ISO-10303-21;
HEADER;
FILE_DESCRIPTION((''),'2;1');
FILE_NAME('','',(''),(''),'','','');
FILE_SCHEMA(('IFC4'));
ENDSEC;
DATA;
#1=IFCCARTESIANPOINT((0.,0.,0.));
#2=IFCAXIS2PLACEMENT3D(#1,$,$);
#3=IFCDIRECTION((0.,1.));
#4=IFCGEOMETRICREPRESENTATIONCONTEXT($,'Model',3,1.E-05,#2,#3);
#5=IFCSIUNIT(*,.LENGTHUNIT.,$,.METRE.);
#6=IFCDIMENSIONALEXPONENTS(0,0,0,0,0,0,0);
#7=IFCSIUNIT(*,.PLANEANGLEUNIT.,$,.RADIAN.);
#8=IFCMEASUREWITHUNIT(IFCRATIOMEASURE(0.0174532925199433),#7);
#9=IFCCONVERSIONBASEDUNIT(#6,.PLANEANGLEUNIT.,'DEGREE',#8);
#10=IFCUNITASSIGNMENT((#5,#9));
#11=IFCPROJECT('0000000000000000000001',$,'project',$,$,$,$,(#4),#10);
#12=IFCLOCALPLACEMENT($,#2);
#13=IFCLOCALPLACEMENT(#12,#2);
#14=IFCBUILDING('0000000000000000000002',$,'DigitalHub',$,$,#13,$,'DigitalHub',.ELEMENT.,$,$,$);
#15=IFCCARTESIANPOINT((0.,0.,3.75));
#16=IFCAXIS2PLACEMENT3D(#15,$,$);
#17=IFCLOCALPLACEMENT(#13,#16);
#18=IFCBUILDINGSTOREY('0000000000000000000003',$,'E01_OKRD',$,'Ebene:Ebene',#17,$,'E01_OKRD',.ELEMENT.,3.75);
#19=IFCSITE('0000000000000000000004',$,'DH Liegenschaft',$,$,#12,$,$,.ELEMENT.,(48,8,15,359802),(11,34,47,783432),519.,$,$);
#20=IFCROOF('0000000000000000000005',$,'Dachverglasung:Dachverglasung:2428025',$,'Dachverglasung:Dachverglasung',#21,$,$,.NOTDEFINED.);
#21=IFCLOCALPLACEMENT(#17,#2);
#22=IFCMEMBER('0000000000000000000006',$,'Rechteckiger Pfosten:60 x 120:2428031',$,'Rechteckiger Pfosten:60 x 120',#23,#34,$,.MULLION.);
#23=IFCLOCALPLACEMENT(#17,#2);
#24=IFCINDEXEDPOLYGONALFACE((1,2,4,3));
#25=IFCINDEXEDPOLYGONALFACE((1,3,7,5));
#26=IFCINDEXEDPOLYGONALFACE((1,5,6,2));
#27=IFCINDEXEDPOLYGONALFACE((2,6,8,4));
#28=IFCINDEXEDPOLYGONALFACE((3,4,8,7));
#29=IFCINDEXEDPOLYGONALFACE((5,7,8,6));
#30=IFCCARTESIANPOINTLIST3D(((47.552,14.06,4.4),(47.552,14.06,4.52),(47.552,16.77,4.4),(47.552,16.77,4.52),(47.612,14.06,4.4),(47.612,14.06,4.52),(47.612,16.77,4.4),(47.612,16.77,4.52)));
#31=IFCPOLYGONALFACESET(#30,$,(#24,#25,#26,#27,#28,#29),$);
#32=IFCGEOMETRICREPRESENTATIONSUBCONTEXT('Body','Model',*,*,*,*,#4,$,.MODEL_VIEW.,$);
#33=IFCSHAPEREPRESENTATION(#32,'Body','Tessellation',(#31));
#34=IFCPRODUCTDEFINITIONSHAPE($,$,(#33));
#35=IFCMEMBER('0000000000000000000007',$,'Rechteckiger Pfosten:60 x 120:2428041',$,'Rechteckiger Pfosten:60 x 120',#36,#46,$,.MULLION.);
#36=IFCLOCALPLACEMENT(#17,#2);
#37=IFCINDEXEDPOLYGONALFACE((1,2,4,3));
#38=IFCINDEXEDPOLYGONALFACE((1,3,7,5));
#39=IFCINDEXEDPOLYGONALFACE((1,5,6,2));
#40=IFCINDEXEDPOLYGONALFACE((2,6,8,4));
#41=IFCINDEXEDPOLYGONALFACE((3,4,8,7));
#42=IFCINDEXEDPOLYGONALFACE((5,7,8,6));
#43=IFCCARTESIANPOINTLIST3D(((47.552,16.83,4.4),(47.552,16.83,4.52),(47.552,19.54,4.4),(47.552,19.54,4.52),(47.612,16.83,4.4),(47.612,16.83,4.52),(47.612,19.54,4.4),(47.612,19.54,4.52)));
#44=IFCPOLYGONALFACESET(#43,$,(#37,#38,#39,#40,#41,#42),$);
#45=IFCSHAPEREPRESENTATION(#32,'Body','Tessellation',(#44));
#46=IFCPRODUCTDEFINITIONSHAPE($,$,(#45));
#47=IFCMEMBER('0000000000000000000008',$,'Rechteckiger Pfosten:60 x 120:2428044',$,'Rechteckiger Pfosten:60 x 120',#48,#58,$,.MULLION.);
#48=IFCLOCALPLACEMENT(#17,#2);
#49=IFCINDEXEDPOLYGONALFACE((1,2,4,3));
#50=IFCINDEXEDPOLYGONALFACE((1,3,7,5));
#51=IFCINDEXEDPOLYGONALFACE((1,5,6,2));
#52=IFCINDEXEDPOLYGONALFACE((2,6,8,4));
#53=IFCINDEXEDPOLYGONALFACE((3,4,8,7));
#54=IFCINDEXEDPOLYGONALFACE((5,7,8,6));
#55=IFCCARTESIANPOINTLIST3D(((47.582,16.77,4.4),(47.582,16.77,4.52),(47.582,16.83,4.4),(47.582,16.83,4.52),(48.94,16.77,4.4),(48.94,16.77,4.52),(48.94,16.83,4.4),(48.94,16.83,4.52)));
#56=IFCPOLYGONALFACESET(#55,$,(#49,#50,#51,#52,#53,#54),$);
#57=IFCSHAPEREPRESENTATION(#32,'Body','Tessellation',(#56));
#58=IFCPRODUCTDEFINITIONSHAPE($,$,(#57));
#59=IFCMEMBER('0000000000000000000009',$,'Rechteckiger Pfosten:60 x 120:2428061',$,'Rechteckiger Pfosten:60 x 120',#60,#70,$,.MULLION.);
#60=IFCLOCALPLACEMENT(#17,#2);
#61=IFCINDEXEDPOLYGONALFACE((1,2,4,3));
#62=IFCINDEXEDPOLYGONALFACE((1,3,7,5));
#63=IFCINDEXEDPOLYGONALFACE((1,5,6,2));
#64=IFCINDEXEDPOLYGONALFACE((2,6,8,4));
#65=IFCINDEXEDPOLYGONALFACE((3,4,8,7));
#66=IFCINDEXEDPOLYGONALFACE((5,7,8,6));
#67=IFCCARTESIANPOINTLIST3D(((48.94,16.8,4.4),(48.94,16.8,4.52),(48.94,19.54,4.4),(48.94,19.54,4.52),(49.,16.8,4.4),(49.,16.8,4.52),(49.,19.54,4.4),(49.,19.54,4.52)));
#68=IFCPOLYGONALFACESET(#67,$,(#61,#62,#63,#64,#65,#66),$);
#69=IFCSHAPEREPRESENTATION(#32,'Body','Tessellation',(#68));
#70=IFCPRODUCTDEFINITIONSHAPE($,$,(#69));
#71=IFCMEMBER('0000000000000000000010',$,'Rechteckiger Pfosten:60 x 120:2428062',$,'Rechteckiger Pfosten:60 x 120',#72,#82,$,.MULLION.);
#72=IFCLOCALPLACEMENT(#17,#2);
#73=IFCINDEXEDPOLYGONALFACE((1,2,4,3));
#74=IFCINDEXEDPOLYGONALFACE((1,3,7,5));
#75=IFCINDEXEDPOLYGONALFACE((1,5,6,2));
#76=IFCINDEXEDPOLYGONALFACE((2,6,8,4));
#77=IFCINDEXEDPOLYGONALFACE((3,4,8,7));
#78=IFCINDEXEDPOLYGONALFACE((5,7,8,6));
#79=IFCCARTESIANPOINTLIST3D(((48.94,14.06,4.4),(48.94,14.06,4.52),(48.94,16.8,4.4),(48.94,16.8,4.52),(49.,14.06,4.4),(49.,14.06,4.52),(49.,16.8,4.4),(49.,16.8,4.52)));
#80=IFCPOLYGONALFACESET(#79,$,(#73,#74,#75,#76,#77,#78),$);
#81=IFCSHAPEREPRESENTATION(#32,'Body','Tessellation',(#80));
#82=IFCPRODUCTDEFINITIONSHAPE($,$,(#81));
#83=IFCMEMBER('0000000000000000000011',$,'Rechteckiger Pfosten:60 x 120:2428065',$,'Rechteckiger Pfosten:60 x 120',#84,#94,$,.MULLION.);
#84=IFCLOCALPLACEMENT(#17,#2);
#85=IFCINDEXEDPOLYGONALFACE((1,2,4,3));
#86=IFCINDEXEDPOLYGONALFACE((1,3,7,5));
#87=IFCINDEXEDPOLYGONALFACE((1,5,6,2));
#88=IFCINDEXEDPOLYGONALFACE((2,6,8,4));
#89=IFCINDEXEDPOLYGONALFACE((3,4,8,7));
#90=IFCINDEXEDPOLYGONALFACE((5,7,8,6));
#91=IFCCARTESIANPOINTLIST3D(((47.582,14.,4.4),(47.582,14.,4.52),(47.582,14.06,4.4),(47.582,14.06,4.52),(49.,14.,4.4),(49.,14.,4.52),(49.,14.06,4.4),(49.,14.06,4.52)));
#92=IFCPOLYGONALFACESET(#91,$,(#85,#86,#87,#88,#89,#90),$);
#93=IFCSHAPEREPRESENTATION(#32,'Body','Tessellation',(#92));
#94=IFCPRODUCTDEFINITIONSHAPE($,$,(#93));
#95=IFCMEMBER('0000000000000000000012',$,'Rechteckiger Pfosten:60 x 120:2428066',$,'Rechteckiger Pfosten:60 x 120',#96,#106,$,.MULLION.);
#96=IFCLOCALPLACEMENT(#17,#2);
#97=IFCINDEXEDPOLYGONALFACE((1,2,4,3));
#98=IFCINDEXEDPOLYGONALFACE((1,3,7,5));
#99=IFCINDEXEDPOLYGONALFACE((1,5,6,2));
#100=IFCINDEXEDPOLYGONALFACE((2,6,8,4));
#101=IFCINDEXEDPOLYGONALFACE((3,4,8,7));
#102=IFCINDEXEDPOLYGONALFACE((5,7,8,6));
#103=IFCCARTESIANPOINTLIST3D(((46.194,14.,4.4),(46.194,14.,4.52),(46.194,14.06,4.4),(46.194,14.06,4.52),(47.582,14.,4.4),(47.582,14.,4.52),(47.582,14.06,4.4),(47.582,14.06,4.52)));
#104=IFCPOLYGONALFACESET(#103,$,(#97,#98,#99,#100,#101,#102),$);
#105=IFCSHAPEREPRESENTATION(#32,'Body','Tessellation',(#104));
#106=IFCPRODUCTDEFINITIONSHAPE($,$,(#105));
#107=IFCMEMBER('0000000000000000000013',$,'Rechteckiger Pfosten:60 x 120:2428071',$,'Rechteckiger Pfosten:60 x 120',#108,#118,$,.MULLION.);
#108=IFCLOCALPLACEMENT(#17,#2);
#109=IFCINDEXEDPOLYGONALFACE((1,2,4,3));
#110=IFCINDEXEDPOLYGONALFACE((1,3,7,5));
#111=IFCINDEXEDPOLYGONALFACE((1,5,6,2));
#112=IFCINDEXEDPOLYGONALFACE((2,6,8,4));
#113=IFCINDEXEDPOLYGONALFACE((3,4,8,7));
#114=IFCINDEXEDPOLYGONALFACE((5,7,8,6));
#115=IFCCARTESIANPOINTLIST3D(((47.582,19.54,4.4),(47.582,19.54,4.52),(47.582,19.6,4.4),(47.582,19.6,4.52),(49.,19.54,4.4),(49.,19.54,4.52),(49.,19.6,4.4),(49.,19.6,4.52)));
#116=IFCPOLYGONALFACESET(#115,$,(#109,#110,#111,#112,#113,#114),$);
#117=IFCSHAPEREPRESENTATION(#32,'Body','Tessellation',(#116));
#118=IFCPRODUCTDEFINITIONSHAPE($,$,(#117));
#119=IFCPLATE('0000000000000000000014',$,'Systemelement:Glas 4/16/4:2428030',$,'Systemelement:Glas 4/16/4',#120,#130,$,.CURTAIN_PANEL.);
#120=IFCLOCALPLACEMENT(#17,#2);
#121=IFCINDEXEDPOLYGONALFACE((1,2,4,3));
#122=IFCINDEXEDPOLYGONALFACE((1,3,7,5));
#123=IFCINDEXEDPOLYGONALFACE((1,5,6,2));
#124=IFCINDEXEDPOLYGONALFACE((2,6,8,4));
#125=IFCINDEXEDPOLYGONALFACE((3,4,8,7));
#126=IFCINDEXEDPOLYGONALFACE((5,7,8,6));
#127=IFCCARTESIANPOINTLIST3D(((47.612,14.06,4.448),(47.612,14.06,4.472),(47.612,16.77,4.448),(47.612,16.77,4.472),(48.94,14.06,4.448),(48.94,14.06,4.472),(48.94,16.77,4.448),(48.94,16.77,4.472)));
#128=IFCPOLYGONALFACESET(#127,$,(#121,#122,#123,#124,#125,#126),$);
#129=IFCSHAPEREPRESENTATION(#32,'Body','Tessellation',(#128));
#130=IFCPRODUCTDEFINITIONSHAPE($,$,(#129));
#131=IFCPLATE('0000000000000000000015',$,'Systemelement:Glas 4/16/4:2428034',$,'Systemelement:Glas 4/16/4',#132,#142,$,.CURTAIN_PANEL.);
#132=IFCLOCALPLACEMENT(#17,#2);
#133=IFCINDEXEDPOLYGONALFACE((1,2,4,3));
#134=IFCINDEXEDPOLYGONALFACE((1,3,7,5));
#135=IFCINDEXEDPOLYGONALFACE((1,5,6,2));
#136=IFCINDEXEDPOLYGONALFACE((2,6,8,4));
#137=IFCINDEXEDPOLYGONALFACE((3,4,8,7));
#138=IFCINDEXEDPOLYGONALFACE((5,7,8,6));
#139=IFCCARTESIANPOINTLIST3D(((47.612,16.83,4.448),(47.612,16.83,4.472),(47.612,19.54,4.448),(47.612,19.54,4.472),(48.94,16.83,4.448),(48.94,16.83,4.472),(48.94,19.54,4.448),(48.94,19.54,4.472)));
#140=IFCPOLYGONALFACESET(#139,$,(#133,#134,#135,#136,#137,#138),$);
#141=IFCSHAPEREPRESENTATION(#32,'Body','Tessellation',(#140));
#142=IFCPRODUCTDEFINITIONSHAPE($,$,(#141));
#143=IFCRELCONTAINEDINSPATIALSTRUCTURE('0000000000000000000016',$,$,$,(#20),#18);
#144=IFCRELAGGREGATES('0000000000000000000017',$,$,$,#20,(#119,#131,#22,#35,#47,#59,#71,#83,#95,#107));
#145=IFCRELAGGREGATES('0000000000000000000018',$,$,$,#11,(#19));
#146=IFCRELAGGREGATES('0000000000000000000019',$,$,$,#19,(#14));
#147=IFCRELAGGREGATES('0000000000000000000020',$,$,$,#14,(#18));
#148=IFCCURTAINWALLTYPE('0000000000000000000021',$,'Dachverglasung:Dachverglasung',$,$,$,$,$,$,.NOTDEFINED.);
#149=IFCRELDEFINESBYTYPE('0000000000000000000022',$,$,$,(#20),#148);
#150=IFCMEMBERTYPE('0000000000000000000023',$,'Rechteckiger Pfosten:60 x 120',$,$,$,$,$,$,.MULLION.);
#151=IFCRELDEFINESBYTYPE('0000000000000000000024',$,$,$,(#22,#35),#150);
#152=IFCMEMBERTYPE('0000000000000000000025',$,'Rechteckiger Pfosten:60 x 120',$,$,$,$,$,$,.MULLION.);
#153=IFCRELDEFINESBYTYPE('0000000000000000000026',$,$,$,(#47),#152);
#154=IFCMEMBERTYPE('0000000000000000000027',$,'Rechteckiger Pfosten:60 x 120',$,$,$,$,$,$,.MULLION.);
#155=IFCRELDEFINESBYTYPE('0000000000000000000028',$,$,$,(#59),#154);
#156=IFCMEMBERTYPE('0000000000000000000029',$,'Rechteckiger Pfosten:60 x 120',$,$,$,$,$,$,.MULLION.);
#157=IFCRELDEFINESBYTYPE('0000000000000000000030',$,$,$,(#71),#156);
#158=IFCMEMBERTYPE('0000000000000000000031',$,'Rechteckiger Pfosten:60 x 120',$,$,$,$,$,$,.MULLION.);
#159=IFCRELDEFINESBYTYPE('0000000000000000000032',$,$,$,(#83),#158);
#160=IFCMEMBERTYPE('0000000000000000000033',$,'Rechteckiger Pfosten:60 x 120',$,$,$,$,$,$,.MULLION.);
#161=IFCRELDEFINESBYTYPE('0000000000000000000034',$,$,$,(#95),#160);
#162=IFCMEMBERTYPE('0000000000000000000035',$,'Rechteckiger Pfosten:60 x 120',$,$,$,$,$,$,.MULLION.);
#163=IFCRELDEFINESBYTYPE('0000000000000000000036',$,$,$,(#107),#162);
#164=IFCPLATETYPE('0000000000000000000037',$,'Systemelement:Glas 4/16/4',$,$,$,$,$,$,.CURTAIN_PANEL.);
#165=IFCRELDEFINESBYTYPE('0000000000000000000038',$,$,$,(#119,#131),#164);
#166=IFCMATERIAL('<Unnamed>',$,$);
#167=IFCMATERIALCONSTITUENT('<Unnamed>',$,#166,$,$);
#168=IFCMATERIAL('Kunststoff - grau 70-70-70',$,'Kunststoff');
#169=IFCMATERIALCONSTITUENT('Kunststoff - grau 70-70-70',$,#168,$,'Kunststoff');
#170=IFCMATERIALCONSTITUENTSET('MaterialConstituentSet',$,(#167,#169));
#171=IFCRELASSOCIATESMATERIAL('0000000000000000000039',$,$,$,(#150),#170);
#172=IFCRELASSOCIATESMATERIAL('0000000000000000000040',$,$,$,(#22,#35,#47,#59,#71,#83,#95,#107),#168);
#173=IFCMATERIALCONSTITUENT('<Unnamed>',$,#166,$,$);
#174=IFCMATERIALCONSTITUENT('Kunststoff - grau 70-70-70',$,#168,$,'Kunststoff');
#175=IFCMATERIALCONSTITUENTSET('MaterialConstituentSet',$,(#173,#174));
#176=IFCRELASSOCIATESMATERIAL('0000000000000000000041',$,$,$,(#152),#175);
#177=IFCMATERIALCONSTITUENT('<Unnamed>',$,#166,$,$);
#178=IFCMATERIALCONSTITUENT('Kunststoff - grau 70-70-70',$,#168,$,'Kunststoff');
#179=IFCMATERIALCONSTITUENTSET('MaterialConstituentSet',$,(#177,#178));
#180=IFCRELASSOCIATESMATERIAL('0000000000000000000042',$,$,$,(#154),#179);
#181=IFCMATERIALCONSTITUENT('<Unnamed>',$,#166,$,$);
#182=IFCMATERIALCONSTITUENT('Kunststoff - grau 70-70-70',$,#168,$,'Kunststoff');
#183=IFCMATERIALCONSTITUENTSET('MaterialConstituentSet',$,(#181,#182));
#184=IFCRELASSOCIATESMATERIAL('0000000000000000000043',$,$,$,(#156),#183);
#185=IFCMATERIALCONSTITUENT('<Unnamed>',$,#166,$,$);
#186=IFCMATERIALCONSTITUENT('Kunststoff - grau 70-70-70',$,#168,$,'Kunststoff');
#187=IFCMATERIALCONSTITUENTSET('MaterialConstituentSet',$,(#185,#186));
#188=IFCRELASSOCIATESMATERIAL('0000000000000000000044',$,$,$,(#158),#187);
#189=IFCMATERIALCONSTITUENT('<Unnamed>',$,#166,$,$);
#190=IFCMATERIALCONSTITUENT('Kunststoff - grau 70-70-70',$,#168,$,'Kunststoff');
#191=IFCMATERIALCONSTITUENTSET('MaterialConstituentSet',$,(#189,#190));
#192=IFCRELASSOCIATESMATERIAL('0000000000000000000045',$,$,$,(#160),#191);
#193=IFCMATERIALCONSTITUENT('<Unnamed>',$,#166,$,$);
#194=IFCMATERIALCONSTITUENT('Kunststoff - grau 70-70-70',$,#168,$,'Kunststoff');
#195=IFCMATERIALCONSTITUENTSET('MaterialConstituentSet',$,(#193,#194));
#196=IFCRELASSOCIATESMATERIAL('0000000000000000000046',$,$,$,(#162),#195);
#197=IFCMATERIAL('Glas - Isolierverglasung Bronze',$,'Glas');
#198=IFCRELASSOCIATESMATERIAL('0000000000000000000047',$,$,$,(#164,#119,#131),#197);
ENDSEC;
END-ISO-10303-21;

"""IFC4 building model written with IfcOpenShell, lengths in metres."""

from ifc_helpers import new_model, entity, si_unit, converted_unit, direction, frame, origin, place, context, subcontext, project, spatial, indexed_curve, outline, extrude, source, transform, mapped, material, constituent, constituent_set, type_object, type_shapes, element, aggregate, save


model = new_model("IFC4")

# Units and contexts
model_context = context("Model", 3, precision=1e-05, world=origin(), true_north=direction((0.0, 1.0)))
body_context = subcontext(model_context, "Body", "Model", "MODEL_VIEW")
ifc_project = project(units=[si_unit("LENGTHUNIT", "METRE"), converted_unit("PLANEANGLEUNIT", "DEGREE", entity("IfcRatioMeasure", 0.0174532925199433), si_unit("PLANEANGLEUNIT", "RADIAN"), dimensions=[0, 0, 0, 0, 0, 0, 0])], contexts=[model_context])

# Site, building, storey
site_placement = place(None, frame((0.0, 0.0, 0.0)))
site = spatial("IfcSite", under=ifc_project, at=site_placement, Name="DH Liegenschaft", CompositionType="ELEMENT", RefLatitude=(48, 8, 15, 359802), RefLongitude=(11, 34, 47, 783432), RefElevation=519.0)
building_placement = place(site_placement, origin())
building = spatial("IfcBuilding", under=site, at=building_placement, Name="DigitalHub", LongName="DigitalHub", CompositionType="ELEMENT")
storey_placement = place(building_placement, frame((0.0, 0.0, 3.75)))
storey = spatial("IfcBuildingStorey", under=building, at=storey_placement, Name="E01_OKRD", ObjectType="Ebene:Ebene", LongName="E01_OKRD", CompositionType="ELEMENT", Elevation=3.75)

# Roof, members, plates
curtain_wall_type = type_object("IfcCurtainWallType", Name="Dachverglasung:Dachverglasung", PredefinedType="NOTDEFINED")
roof_placement = place(storey_placement, frame((0.0, 0.0, -3.75)))
roof = element("IfcRoof", 1, at=roof_placement, inside=storey, type_object=curtain_wall_type, Name="Dachverglasung:Dachverglasung:2428025", ObjectType="Dachverglasung:Dachverglasung", PredefinedType="NOTDEFINED")
ifc_material_1 = material(Name="Kunststoff - grau 70-70-70", Category="Kunststoff")
ifc_material_2 = material(Name="<Unnamed>")
ifc_constituent_1 = constituent(ifc_material_2, Name="<Unnamed>")
ifc_constituent_2 = constituent(ifc_material_1, Name="Kunststoff - grau 70-70-70", Category="Kunststoff")
ifc_constituent_set_1 = constituent_set(constituents=[ifc_constituent_1, ifc_constituent_2], Name="MaterialConstituentSet")
member_type_1 = type_object("IfcMemberType", Name="Rechteckiger Pfosten:60 x 120", PredefinedType="MULLION", material=ifc_constituent_set_1)
shared_shape_1 = source(origin(), body_context, "Body", "SweptSolid", [
    extrude(outline(indexed_curve([(-0.06, -0.03), (0.06, -0.03), (0.06, 0.03), (-0.06, 0.03), (-0.06, -0.03)], self_intersect=False)), frame((0.0, 0.0, -2.71), z_axis=(0.0, 0.0, 1.0), x_axis=(0.0, -1.0, 0.0)), (0.0, 0.0, 1.0), 2.71),
])
type_shapes(member_type_1, [shared_shape_1])
member_1_placement = place(storey_placement, frame((47.582, 14.06, 4.46), z_axis=(0.0, -1.0, 0.0), x_axis=(-1.0, 0.0, 0.0)))
member_1 = element("IfcMember", 2, at=member_1_placement, type_object=member_type_1, material=ifc_material_1, Name="Rechteckiger Pfosten:60 x 120:2428031", ObjectType="Rechteckiger Pfosten:60 x 120", PredefinedType="MULLION", context=body_context, shape_type="MappedRepresentation", body=[
    mapped(shared_shape_1, transform((0.0, 0.0, 0.0), scale=1.0)),
])
member_2_placement = place(storey_placement, frame((47.582, 16.83, 4.46), z_axis=(0.0, -1.0, 0.0), x_axis=(-1.0, 0.0, 0.0)))
member_2 = element("IfcMember", 3, at=member_2_placement, type_object=member_type_1, material=ifc_material_1, Name="Rechteckiger Pfosten:60 x 120:2428041", ObjectType="Rechteckiger Pfosten:60 x 120", PredefinedType="MULLION", context=body_context, shape_type="MappedRepresentation", body=[
    mapped(shared_shape_1, transform((0.0, 0.0, 0.0), scale=1.0)),
])
ifc_constituent_3 = constituent(ifc_material_2, Name="<Unnamed>")
ifc_constituent_4 = constituent(ifc_material_1, Name="Kunststoff - grau 70-70-70", Category="Kunststoff")
ifc_constituent_set_2 = constituent_set(constituents=[ifc_constituent_3, ifc_constituent_4], Name="MaterialConstituentSet")
member_type_2 = type_object("IfcMemberType", Name="Rechteckiger Pfosten:60 x 120", PredefinedType="MULLION", material=ifc_constituent_set_2)
shared_shape_2 = source(origin(), body_context, "Body", "SweptSolid", [
    extrude(outline(indexed_curve([(-0.06, -0.03), (0.06, -0.03), (0.06, 0.03), (-0.06, 0.03), (-0.06, -0.03)], self_intersect=False)), frame((0.0, 0.0, -1.358), z_axis=(0.0, 0.0, 1.0), x_axis=(0.0, -1.0, 0.0)), (0.0, 0.0, 1.0), 1.358),
])
type_shapes(member_type_2, [shared_shape_2])
member_3_placement = place(storey_placement, frame((47.582, 16.8, 4.46), z_axis=(-1.0, 0.0, 0.0), x_axis=(0.0, 1.0, 0.0)))
member_3 = element("IfcMember", 4, at=member_3_placement, type_object=member_type_2, material=ifc_material_1, Name="Rechteckiger Pfosten:60 x 120:2428044", ObjectType="Rechteckiger Pfosten:60 x 120", PredefinedType="MULLION", context=body_context, shape_type="MappedRepresentation", body=[
    mapped(shared_shape_2, transform((0.0, 0.0, 0.0), scale=1.0)),
])
ifc_constituent_5 = constituent(ifc_material_2, Name="<Unnamed>")
ifc_constituent_6 = constituent(ifc_material_1, Name="Kunststoff - grau 70-70-70", Category="Kunststoff")
ifc_constituent_set_3 = constituent_set(constituents=[ifc_constituent_5, ifc_constituent_6], Name="MaterialConstituentSet")
member_type_3 = type_object("IfcMemberType", Name="Rechteckiger Pfosten:60 x 120", PredefinedType="MULLION", material=ifc_constituent_set_3)
shared_shape_3 = source(origin(), body_context, "Body", "SweptSolid", [
    extrude(outline(indexed_curve([(-0.06, -0.03), (0.06, -0.03), (0.06, 0.03), (-0.06, 0.03), (-0.06, -0.03)], self_intersect=False)), frame((-0.03, 0.0, -2.74), z_axis=(0.0, 0.0, 1.0), x_axis=(0.0, -1.0, 0.0)), (0.0, 0.0, 1.0), 2.74),
])
type_shapes(member_type_3, [shared_shape_3])
member_4_placement = place(storey_placement, frame((49.0, 19.54, 4.46), z_axis=(0.0, 1.0, 0.0), x_axis=(1.0, 0.0, 0.0)))
member_4 = element("IfcMember", 5, at=member_4_placement, type_object=member_type_3, material=ifc_material_1, Name="Rechteckiger Pfosten:60 x 120:2428061", ObjectType="Rechteckiger Pfosten:60 x 120", PredefinedType="MULLION", context=body_context, shape_type="MappedRepresentation", body=[
    mapped(shared_shape_3, transform((0.0, 0.0, 0.0), scale=1.0)),
])
ifc_constituent_7 = constituent(ifc_material_2, Name="<Unnamed>")
ifc_constituent_8 = constituent(ifc_material_1, Name="Kunststoff - grau 70-70-70", Category="Kunststoff")
ifc_constituent_set_4 = constituent_set(constituents=[ifc_constituent_7, ifc_constituent_8], Name="MaterialConstituentSet")
member_type_4 = type_object("IfcMemberType", Name="Rechteckiger Pfosten:60 x 120", PredefinedType="MULLION", material=ifc_constituent_set_4)
shared_shape_4 = source(origin(), body_context, "Body", "SweptSolid", [
    extrude(outline(indexed_curve([(-0.06, -0.03), (0.06, -0.03), (0.06, 0.03), (-0.06, 0.03), (-0.06, -0.03)], self_intersect=False)), frame((-0.03, 0.0, -2.74), z_axis=(0.0, 0.0, 1.0), x_axis=(0.0, -1.0, 0.0)), (0.0, 0.0, 1.0), 2.74),
])
type_shapes(member_type_4, [shared_shape_4])
member_5_placement = place(storey_placement, frame((49.0, 16.8, 4.46), z_axis=(0.0, 1.0, 0.0), x_axis=(1.0, 0.0, 0.0)))
member_5 = element("IfcMember", 6, at=member_5_placement, type_object=member_type_4, material=ifc_material_1, Name="Rechteckiger Pfosten:60 x 120:2428062", ObjectType="Rechteckiger Pfosten:60 x 120", PredefinedType="MULLION", context=body_context, shape_type="MappedRepresentation", body=[
    mapped(shared_shape_4, transform((0.0, 0.0, 0.0), scale=1.0)),
])
ifc_constituent_9 = constituent(ifc_material_2, Name="<Unnamed>")
ifc_constituent_10 = constituent(ifc_material_1, Name="Kunststoff - grau 70-70-70", Category="Kunststoff")
ifc_constituent_set_5 = constituent_set(constituents=[ifc_constituent_9, ifc_constituent_10], Name="MaterialConstituentSet")
member_type_5 = type_object("IfcMemberType", Name="Rechteckiger Pfosten:60 x 120", PredefinedType="MULLION", material=ifc_constituent_set_5)
shared_shape_5 = source(origin(), body_context, "Body", "SweptSolid", [
    extrude(outline(indexed_curve([(-0.06, -0.03), (0.06, -0.03), (0.06, 0.03), (-0.06, 0.03), (-0.06, -0.03)], self_intersect=False)), frame((-0.03, 0.0, -1.418), z_axis=(0.0, 0.0, 1.0), x_axis=(0.0, -1.0, 0.0)), (0.0, 0.0, 1.0), 1.418),
])
type_shapes(member_type_5, [shared_shape_5])
member_6_placement = place(storey_placement, frame((49.0, 14.0, 4.46), z_axis=(1.0, 0.0, 0.0), x_axis=(0.0, -1.0, 0.0)))
member_6 = element("IfcMember", 7, at=member_6_placement, type_object=member_type_5, material=ifc_material_1, Name="Rechteckiger Pfosten:60 x 120:2428065", ObjectType="Rechteckiger Pfosten:60 x 120", PredefinedType="MULLION", context=body_context, shape_type="MappedRepresentation", body=[
    mapped(shared_shape_5, transform((0.0, 0.0, 0.0), scale=1.0)),
])
ifc_constituent_11 = constituent(ifc_material_2, Name="<Unnamed>")
ifc_constituent_12 = constituent(ifc_material_1, Name="Kunststoff - grau 70-70-70", Category="Kunststoff")
ifc_constituent_set_6 = constituent_set(constituents=[ifc_constituent_11, ifc_constituent_12], Name="MaterialConstituentSet")
member_type_6 = type_object("IfcMemberType", Name="Rechteckiger Pfosten:60 x 120", PredefinedType="MULLION", material=ifc_constituent_set_6)
shared_shape_6 = source(origin(), body_context, "Body", "SweptSolid", [
    extrude(outline(indexed_curve([(-0.06, -0.03), (0.06, -0.03), (0.06, 0.03), (-0.06, 0.03), (-0.06, -0.03)], self_intersect=False)), frame((-0.03, 0.0, -1.388), z_axis=(0.0, 0.0, 1.0), x_axis=(0.0, -1.0, 0.0)), (0.0, 0.0, 1.0), 1.388),
])
type_shapes(member_type_6, [shared_shape_6])
member_7_placement = place(storey_placement, frame((47.582, 14.0, 4.46), z_axis=(1.0, 0.0, 0.0), x_axis=(0.0, -1.0, 0.0)))
member_7 = element("IfcMember", 8, at=member_7_placement, type_object=member_type_6, material=ifc_material_1, Name="Rechteckiger Pfosten:60 x 120:2428066", ObjectType="Rechteckiger Pfosten:60 x 120", PredefinedType="MULLION", context=body_context, shape_type="MappedRepresentation", body=[
    mapped(shared_shape_6, transform((0.0, 0.0, 0.0), scale=1.0)),
])
ifc_constituent_13 = constituent(ifc_material_2, Name="<Unnamed>")
ifc_constituent_14 = constituent(ifc_material_1, Name="Kunststoff - grau 70-70-70", Category="Kunststoff")
ifc_constituent_set_7 = constituent_set(constituents=[ifc_constituent_13, ifc_constituent_14], Name="MaterialConstituentSet")
member_type_7 = type_object("IfcMemberType", Name="Rechteckiger Pfosten:60 x 120", PredefinedType="MULLION", material=ifc_constituent_set_7)
shared_shape_7 = source(origin(), body_context, "Body", "SweptSolid", [
    extrude(outline(indexed_curve([(-0.06, -0.03), (0.06, -0.03), (0.06, 0.03), (-0.06, 0.03), (-0.06, -0.03)], self_intersect=False)), frame((-0.03, 0.0, -1.418), z_axis=(0.0, 0.0, 1.0), x_axis=(0.0, -1.0, 0.0)), (0.0, 0.0, 1.0), 1.418),
])
type_shapes(member_type_7, [shared_shape_7])
member_8_placement = place(storey_placement, frame((47.582, 19.6, 4.46), z_axis=(-1.0, 0.0, 0.0), x_axis=(0.0, 1.0, 0.0)))
member_8 = element("IfcMember", 9, at=member_8_placement, type_object=member_type_7, material=ifc_material_1, Name="Rechteckiger Pfosten:60 x 120:2428071", ObjectType="Rechteckiger Pfosten:60 x 120", PredefinedType="MULLION", context=body_context, shape_type="MappedRepresentation", body=[
    mapped(shared_shape_7, transform((0.0, 0.0, 0.0), scale=1.0)),
])
ifc_material_3 = material(Name="Glas - Isolierverglasung Bronze", Category="Glas")
plate_type = type_object("IfcPlateType", Name="Systemelement:Glas 4/16/4", PredefinedType="CURTAIN_PANEL", material=ifc_material_3)
shared_shape_8 = source(origin(), body_context, "Body", "SweptSolid", [
    extrude(outline(indexed_curve([(-0.012, -1.355), (0.012, -1.355), (0.012, 1.355), (-0.012, 1.355), (-0.012, -1.355)], self_intersect=False)), frame((0.0, 0.0, 0.0), z_axis=(0.0, 0.0, 1.0), x_axis=(0.0, 1.0, 0.0)), (0.0, 0.0, 1.0), 1.328),
])
type_shapes(plate_type, [shared_shape_8])
plate_1_placement = place(roof_placement, frame((48.94, 15.415, 8.21), z_axis=(-1.0, 0.0, 0.0), x_axis=(0.0, 1.0, 0.0)))
plate_1 = element("IfcPlate", 10, at=plate_1_placement, type_object=plate_type, material=ifc_material_3, Name="Systemelement:Glas 4/16/4:2428030", ObjectType="Systemelement:Glas 4/16/4", PredefinedType="CURTAIN_PANEL", context=body_context, shape_type="MappedRepresentation", body=[
    mapped(shared_shape_8, transform((0.0, 0.0, 0.0), scale=1.0)),
])
plate_2_placement = place(roof_placement, frame((48.94, 18.185, 8.21), z_axis=(-1.0, 0.0, 0.0), x_axis=(0.0, 1.0, 0.0)))
plate_2 = element("IfcPlate", 11, at=plate_2_placement, type_object=plate_type, material=ifc_material_3, Name="Systemelement:Glas 4/16/4:2428034", ObjectType="Systemelement:Glas 4/16/4", PredefinedType="CURTAIN_PANEL", context=body_context, shape_type="MappedRepresentation", body=[
    mapped(shared_shape_8, transform((0.0, 0.0, 0.0), scale=1.0)),
])
aggregate(roof, [plate_1, plate_2, member_1, member_2, member_3, member_4, member_5, member_6, member_7, member_8])

save(model, "model.ifc")
